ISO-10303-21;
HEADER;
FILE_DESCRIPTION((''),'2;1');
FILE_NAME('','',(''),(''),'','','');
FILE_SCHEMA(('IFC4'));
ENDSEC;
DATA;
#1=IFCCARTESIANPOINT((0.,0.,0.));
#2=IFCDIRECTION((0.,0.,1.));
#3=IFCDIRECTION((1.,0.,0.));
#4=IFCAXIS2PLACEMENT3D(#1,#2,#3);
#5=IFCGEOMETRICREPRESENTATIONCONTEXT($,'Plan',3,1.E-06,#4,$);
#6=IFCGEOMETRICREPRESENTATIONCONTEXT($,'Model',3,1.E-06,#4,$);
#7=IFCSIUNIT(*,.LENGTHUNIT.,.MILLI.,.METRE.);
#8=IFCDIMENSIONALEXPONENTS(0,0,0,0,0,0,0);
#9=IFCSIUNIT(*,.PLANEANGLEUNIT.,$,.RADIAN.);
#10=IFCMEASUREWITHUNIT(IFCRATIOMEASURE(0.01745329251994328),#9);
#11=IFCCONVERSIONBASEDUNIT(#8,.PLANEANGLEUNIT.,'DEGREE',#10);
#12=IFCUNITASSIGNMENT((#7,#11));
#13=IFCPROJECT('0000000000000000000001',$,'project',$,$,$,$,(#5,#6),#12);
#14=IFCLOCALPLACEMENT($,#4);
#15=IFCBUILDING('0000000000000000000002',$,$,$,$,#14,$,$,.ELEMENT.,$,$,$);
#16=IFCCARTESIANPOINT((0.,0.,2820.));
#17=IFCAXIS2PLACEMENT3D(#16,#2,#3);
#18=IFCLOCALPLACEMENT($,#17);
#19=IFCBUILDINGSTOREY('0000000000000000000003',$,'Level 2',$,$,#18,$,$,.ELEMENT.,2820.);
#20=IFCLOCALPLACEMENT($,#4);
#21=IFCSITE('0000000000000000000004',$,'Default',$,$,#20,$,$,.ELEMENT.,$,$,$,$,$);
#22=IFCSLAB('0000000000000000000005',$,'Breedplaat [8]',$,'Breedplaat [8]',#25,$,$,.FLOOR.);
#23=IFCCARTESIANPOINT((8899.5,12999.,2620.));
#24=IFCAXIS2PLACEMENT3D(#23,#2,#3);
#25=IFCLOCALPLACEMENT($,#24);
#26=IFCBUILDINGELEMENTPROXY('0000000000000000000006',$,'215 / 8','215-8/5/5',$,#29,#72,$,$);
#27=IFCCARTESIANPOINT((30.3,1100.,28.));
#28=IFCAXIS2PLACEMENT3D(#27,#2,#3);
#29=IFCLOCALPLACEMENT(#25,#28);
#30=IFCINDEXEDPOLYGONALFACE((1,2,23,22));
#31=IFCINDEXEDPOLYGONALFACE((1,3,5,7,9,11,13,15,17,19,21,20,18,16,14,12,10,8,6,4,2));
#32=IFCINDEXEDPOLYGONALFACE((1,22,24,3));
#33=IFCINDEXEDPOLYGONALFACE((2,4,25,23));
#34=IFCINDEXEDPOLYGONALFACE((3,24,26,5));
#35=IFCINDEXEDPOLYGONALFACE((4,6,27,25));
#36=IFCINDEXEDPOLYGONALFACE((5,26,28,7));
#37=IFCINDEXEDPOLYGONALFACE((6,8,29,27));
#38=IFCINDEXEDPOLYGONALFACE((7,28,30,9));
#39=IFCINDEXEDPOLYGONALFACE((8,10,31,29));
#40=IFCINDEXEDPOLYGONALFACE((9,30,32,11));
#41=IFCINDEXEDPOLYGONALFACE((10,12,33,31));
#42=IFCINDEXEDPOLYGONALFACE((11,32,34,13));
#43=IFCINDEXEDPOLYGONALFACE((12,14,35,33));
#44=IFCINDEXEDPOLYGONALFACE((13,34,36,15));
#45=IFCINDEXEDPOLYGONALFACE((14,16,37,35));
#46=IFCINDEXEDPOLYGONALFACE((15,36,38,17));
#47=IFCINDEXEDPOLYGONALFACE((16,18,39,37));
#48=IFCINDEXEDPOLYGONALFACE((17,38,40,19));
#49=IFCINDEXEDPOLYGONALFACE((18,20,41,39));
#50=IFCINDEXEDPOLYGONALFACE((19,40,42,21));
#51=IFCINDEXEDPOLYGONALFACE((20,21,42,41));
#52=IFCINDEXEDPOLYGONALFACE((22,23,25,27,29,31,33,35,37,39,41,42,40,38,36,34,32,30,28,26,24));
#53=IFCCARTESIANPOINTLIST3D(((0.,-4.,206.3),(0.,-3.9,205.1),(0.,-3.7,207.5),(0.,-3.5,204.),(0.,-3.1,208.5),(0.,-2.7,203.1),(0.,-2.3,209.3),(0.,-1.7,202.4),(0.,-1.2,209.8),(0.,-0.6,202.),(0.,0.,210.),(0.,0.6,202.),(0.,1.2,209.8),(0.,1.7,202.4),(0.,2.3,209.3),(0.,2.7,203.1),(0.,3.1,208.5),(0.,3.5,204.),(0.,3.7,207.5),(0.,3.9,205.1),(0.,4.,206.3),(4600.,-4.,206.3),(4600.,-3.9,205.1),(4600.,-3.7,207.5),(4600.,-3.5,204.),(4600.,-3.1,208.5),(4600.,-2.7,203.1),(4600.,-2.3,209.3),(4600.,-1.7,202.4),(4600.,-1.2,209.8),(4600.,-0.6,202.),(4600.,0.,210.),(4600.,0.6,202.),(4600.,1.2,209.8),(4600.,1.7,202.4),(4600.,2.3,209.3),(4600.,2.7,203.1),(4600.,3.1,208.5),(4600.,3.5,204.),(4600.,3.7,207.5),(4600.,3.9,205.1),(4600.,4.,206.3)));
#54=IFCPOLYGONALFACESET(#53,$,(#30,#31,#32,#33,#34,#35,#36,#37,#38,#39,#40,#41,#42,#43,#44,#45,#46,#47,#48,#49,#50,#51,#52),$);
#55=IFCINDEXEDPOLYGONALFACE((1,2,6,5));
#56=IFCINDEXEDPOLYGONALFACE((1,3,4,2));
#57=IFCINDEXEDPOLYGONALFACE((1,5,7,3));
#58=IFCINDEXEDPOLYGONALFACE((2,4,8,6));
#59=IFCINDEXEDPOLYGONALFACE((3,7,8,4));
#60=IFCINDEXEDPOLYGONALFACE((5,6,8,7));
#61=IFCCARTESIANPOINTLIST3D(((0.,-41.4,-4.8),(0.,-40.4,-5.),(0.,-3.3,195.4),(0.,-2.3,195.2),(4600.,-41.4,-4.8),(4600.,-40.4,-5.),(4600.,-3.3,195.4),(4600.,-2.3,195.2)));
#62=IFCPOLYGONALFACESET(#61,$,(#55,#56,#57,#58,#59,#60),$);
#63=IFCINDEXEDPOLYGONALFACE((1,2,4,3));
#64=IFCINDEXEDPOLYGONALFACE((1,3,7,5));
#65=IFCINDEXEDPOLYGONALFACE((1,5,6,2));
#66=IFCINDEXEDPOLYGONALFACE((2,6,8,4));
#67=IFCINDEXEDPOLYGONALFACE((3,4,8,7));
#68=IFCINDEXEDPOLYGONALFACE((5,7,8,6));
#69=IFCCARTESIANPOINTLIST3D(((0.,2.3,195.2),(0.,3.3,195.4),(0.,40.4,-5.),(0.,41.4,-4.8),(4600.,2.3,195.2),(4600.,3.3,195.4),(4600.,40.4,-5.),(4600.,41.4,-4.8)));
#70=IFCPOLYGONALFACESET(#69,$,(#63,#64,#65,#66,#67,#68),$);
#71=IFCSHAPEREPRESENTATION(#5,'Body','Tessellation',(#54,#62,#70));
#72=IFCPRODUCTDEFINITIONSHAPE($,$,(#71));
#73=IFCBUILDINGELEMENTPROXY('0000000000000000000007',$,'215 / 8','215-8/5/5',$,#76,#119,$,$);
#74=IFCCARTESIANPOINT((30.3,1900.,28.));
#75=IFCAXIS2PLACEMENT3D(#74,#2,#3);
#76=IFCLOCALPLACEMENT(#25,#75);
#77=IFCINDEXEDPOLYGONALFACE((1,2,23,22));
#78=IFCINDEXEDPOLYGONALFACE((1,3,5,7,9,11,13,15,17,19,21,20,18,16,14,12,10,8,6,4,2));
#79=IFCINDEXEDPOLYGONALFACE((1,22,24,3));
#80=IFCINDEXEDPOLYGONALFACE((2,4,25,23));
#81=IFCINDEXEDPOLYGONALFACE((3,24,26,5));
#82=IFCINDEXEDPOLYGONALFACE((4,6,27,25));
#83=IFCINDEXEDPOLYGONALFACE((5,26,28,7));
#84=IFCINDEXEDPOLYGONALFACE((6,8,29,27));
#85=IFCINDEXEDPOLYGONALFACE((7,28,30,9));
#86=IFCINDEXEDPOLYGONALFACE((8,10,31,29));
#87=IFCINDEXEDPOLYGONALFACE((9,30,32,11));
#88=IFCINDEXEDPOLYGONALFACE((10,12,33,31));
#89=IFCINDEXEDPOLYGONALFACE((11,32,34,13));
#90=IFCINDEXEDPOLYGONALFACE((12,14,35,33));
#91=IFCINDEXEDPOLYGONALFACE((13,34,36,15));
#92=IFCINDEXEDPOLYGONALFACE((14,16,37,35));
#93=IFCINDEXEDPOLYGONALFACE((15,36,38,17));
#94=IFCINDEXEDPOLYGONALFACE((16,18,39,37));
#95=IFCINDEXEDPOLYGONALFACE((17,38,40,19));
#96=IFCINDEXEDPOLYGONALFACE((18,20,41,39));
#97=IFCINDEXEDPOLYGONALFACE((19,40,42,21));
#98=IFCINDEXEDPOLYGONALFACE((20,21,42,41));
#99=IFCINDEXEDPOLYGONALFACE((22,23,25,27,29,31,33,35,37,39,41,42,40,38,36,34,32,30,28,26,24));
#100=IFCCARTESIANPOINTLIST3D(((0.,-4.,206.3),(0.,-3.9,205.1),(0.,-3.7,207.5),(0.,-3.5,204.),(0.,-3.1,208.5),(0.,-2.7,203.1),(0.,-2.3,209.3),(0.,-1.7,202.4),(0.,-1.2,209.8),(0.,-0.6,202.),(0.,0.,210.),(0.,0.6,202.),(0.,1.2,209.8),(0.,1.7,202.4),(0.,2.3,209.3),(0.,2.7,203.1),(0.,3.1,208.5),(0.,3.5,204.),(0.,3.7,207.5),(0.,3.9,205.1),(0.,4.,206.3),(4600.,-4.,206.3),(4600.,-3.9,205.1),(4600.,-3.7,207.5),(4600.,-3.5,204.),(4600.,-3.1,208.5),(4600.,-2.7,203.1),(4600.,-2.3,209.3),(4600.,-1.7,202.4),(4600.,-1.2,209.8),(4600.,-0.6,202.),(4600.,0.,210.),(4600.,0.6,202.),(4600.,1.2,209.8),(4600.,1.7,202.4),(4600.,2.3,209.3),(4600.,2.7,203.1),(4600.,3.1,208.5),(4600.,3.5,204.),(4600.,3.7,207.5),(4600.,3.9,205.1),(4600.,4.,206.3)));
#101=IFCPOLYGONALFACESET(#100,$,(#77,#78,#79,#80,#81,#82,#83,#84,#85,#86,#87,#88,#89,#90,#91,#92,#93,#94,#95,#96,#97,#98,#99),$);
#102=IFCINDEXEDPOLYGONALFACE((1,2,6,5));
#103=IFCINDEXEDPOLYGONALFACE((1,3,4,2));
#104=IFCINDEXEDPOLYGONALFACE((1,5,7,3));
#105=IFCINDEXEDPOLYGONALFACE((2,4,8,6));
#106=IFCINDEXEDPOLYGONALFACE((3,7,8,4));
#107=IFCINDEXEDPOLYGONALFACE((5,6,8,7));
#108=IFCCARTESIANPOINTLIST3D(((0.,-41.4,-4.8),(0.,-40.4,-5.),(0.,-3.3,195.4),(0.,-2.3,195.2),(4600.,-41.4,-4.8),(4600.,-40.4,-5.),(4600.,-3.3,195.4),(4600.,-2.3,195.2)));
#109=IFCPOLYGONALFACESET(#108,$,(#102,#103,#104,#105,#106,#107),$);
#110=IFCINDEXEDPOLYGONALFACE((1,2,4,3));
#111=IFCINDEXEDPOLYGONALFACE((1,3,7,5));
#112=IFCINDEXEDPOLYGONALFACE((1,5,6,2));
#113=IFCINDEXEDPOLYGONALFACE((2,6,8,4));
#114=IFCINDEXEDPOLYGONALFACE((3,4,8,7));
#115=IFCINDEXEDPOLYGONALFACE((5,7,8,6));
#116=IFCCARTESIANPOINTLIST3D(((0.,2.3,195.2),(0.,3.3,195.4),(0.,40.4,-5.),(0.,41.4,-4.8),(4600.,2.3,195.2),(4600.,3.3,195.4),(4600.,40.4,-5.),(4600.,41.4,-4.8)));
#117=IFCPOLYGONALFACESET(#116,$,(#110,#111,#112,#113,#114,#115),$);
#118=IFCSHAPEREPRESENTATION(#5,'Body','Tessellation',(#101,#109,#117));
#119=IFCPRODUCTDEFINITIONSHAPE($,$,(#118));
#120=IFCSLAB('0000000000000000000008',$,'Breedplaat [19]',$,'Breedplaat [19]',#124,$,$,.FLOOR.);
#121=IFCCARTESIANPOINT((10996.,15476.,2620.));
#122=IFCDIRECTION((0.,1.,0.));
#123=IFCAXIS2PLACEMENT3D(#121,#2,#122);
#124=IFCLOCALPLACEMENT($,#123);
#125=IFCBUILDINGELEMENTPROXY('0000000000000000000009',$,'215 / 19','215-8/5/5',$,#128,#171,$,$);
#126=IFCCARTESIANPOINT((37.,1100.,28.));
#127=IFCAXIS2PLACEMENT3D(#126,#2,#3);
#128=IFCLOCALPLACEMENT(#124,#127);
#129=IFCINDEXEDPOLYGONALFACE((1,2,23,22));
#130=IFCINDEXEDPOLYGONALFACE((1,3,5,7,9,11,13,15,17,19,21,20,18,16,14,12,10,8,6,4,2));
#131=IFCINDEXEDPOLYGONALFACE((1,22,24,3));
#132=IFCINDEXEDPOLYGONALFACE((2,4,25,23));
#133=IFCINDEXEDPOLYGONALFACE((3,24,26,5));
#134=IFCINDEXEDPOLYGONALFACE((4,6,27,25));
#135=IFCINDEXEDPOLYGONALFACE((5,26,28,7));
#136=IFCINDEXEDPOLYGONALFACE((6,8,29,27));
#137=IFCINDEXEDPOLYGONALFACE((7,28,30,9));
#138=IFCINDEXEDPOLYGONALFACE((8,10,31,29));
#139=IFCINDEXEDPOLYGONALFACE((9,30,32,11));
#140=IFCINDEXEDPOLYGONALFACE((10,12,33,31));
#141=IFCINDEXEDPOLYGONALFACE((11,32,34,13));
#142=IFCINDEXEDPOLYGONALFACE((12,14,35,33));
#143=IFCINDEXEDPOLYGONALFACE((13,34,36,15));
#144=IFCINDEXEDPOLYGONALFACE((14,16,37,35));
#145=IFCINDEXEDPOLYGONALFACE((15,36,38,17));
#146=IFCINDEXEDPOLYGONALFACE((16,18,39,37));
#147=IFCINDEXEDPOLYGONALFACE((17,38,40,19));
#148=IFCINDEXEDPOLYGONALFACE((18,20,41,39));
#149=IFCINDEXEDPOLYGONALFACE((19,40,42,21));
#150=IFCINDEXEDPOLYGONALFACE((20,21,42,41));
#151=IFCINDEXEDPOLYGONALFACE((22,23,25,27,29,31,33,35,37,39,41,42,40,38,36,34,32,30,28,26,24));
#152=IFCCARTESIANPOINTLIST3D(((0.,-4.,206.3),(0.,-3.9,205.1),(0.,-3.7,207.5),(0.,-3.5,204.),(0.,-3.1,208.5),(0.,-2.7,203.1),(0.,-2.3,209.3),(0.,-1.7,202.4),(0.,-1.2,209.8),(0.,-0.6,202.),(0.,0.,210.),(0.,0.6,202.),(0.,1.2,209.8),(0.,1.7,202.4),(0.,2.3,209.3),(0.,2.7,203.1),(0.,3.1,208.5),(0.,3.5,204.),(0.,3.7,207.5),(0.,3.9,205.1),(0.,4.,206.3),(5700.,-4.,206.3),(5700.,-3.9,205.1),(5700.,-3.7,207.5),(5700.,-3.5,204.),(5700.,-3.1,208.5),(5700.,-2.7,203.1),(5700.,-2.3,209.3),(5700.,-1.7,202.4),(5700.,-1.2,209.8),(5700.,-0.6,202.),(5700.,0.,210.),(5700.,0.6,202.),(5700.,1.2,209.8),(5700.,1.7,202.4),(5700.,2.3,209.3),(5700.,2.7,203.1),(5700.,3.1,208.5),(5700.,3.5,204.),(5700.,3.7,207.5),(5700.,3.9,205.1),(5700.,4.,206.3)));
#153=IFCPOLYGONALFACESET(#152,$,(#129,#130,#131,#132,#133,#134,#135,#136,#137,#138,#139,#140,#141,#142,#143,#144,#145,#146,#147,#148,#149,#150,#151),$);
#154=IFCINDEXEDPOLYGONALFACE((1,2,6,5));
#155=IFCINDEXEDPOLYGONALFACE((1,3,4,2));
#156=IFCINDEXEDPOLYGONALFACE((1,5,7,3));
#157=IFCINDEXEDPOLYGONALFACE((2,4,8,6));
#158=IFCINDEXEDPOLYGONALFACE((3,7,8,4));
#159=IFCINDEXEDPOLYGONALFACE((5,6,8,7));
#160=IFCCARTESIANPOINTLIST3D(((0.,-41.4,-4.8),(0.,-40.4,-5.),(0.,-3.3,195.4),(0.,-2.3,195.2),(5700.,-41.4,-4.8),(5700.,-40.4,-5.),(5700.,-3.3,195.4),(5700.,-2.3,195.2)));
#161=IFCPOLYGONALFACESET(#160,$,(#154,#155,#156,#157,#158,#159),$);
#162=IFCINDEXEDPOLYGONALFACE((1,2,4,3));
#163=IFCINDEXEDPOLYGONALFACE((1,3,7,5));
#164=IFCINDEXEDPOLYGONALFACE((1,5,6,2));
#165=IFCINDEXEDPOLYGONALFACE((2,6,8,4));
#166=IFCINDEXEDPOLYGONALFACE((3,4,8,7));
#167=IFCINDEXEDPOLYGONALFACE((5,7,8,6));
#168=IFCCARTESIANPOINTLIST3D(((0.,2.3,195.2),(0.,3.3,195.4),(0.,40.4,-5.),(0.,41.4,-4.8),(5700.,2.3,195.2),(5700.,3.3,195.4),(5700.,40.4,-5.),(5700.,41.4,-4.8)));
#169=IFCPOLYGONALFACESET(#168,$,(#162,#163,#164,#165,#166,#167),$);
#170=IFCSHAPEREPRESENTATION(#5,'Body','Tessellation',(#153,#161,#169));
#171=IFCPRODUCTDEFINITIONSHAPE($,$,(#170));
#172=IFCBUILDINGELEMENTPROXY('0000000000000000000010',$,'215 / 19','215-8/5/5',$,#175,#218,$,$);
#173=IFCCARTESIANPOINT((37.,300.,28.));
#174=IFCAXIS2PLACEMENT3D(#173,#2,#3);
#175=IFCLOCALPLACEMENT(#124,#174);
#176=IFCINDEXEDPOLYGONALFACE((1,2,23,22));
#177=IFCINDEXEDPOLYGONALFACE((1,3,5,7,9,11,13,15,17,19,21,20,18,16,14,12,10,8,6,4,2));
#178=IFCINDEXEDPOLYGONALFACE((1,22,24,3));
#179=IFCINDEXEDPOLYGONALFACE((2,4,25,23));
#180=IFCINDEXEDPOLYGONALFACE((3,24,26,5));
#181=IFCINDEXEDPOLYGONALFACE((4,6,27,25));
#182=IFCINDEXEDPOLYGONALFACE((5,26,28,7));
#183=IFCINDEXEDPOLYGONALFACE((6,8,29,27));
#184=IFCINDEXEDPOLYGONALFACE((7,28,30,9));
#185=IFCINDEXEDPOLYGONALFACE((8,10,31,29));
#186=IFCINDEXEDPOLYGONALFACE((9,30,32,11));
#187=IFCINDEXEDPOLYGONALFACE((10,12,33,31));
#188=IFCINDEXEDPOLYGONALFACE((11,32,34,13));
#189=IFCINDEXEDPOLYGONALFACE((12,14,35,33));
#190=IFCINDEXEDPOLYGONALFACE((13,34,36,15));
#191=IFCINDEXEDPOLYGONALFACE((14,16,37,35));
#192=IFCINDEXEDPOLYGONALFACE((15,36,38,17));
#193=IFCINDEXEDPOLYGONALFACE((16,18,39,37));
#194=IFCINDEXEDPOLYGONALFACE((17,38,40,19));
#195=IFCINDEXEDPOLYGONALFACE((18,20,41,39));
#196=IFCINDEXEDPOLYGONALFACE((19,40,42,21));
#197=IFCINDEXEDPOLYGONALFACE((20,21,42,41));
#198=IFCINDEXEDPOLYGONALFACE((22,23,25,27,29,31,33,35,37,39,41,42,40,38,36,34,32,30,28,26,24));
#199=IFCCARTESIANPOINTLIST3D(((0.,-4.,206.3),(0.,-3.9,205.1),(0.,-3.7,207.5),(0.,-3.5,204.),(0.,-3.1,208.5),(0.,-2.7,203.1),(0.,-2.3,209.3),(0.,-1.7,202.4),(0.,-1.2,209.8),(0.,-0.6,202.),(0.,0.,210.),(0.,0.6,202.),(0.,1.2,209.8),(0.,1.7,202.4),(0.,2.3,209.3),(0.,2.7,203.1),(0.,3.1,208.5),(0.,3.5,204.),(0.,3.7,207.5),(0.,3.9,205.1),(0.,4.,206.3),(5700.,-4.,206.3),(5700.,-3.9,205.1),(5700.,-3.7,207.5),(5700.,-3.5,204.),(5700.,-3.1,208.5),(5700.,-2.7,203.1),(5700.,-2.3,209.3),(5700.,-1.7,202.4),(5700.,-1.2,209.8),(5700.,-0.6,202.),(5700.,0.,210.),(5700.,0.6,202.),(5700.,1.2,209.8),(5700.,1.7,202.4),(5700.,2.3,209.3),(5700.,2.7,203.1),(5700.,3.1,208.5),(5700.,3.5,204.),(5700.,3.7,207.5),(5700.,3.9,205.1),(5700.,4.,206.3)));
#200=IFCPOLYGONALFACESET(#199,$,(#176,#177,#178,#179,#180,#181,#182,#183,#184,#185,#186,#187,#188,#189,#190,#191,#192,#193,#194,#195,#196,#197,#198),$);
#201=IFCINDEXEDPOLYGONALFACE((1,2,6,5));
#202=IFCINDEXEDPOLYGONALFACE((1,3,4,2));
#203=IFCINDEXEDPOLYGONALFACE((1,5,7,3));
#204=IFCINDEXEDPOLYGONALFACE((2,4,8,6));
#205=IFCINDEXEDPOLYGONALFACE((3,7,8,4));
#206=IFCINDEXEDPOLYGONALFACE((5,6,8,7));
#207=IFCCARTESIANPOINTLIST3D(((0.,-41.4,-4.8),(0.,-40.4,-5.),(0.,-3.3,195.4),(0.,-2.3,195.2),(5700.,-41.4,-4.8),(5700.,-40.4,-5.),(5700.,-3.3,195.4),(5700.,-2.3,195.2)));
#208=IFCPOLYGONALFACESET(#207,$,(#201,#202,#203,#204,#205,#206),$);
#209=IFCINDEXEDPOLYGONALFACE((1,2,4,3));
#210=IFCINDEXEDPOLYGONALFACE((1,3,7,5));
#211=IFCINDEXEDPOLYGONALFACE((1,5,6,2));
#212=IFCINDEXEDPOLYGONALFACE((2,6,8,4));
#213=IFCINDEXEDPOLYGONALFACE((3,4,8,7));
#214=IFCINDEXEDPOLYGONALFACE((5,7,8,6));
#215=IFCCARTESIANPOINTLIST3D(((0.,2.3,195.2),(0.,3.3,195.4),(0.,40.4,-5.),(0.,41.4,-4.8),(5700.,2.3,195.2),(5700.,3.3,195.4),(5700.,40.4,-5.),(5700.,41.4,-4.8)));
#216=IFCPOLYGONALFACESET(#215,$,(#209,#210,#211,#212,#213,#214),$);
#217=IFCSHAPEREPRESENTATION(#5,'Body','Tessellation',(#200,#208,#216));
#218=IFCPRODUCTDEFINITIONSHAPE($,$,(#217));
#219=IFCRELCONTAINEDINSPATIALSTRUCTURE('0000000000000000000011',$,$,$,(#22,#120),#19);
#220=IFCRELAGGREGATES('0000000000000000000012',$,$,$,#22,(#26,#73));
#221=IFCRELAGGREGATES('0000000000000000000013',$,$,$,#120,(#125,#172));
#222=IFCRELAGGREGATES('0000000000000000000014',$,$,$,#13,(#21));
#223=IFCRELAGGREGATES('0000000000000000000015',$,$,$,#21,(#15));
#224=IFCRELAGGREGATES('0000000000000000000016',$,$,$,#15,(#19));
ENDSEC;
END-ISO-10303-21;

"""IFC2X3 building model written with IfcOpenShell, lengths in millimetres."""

from ifc_helpers import new_model, entity, si_unit, converted_unit, frame, origin_with_axes, origin_2d_with_axis, place, context, project, spatial, rectangle, circle, extrude, element, aggregate, save


model = new_model("IFC2X3")

# Units and contexts
plan_context = context("Plan", 3, precision=1e-06, world=origin_with_axes())
model_context = context("Model", 3, precision=1e-06, world=origin_with_axes())
ifc_project = project(units=[si_unit("LENGTHUNIT", "METRE", prefix="MILLI"), converted_unit("PLANEANGLEUNIT", "DEGREE", entity("IfcRatioMeasure", 0.01745329251994328), si_unit("PLANEANGLEUNIT", "RADIAN"), dimensions=[0, 0, 0, 0, 0, 0, 0])], contexts=[plan_context, model_context])

# Site, building, storey
site_placement = place(None, origin_with_axes())
site = spatial("IfcSite", under=ifc_project, at=site_placement, Name="Default", CompositionType="ELEMENT")
building_placement = place(None, origin_with_axes())
building = spatial("IfcBuilding", under=site, at=building_placement, CompositionType="ELEMENT")
storey_placement = place(None, frame((0.0, 0.0, 2820.0), z_axis=(0.0, 0.0, 1.0), x_axis=(1.0, 0.0, 0.0)))
storey = spatial("IfcBuildingStorey", under=building, at=storey_placement, Name="Level 2", CompositionType="ELEMENT", Elevation=2820.0)

# Slabs, building element proxies
slab_1_placement = place(None, frame((8899.5, 12999.0, 2620.0), z_axis=(0.0, 0.0, 1.0), x_axis=(1.0, 0.0, 0.0)))
slab_1 = element("IfcSlab", 1, at=slab_1_placement, inside=storey, Name="Breedplaat [8]", ObjectType="Breedplaat [8]", PredefinedType="FLOOR")
proxy_1_placement = place(slab_1_placement, frame((30.3, 1100.0, 28.0), z_axis=(0.0, 0.0, 1.0), x_axis=(1.0, 0.0, 0.0)))
proxy_1 = element("IfcBuildingElementProxy", 2, at=proxy_1_placement, Name="215 / 8", Description="215-8/5/5", context=plan_context, shape_type="SweptSolid", body=[
    extrude(circle(Radius=4.0, at=origin_2d_with_axis()), frame((0.0, 0.0, 206.0), z_axis=(1.0, 0.0, 0.0), x_axis=(0.0, 0.0, 1.0)), (0.0, 0.0, 1.0), 4600.0),
    extrude(rectangle(XDim=203.8, YDim=1.0, at=origin_2d_with_axis()), frame((0.0, -21.9, 95.2), z_axis=(1.0, 0.0, 0.0), x_axis=(0.0, 0.187112, 0.982339)), (0.0, 0.0, 1.0), 4600.0),
    extrude(rectangle(XDim=203.8, YDim=1.0, at=origin_2d_with_axis()), frame((0.0, 21.9, 95.2), z_axis=(1.0, 0.0, 0.0), x_axis=(0.0, -0.187112, 0.982339)), (0.0, 0.0, 1.0), 4600.0),
])
proxy_2_placement = place(slab_1_placement, frame((30.3, 1900.0, 28.0), z_axis=(0.0, 0.0, 1.0), x_axis=(1.0, 0.0, 0.0)))
proxy_2 = element("IfcBuildingElementProxy", 3, at=proxy_2_placement, Name="215 / 8", Description="215-8/5/5", context=plan_context, shape_type="SweptSolid", body=[
    extrude(circle(Radius=4.0, at=origin_2d_with_axis()), frame((0.0, 0.0, 206.0), z_axis=(1.0, 0.0, 0.0), x_axis=(0.0, 0.0, 1.0)), (0.0, 0.0, 1.0), 4600.0),
    extrude(rectangle(XDim=203.8, YDim=1.0, at=origin_2d_with_axis()), frame((0.0, -21.9, 95.2), z_axis=(1.0, 0.0, 0.0), x_axis=(0.0, 0.187112, 0.982339)), (0.0, 0.0, 1.0), 4600.0),
    extrude(rectangle(XDim=203.8, YDim=1.0, at=origin_2d_with_axis()), frame((0.0, 21.9, 95.2), z_axis=(1.0, 0.0, 0.0), x_axis=(0.0, -0.187112, 0.982339)), (0.0, 0.0, 1.0), 4600.0),
])
aggregate(slab_1, [proxy_1, proxy_2])
slab_2_placement = place(None, frame((10996.0, 15476.0, 2620.0), z_axis=(0.0, 0.0, 1.0), x_axis=(0.0, 1.0, 0.0)))
slab_2 = element("IfcSlab", 4, at=slab_2_placement, inside=storey, Name="Breedplaat [19]", ObjectType="Breedplaat [19]", PredefinedType="FLOOR")
proxy_3_placement = place(slab_2_placement, frame((37.0, 1100.0, 28.0), z_axis=(0.0, 0.0, 1.0), x_axis=(1.0, 0.0, 0.0)))
proxy_3 = element("IfcBuildingElementProxy", 5, at=proxy_3_placement, Name="215 / 19", Description="215-8/5/5", context=plan_context, shape_type="SweptSolid", body=[
    extrude(circle(Radius=4.0, at=origin_2d_with_axis()), frame((0.0, 0.0, 206.0), z_axis=(1.0, 0.0, 0.0), x_axis=(0.0, 0.0, 1.0)), (0.0, 0.0, 1.0), 5700.0),
    extrude(rectangle(XDim=203.8, YDim=1.0, at=origin_2d_with_axis()), frame((0.0, -21.9, 95.2), z_axis=(1.0, 0.0, 0.0), x_axis=(0.0, 0.187112, 0.982339)), (0.0, 0.0, 1.0), 5700.0),
    extrude(rectangle(XDim=203.8, YDim=1.0, at=origin_2d_with_axis()), frame((0.0, 21.9, 95.2), z_axis=(1.0, 0.0, 0.0), x_axis=(0.0, -0.187112, 0.982339)), (0.0, 0.0, 1.0), 5700.0),
])
proxy_4_placement = place(slab_2_placement, frame((37.0, 300.0, 28.0), z_axis=(0.0, 0.0, 1.0), x_axis=(1.0, 0.0, 0.0)))
proxy_4 = element("IfcBuildingElementProxy", 6, at=proxy_4_placement, Name="215 / 19", Description="215-8/5/5", context=plan_context, shape_type="SweptSolid", body=[
    extrude(circle(Radius=4.0, at=origin_2d_with_axis()), frame((0.0, 0.0, 206.0), z_axis=(1.0, 0.0, 0.0), x_axis=(0.0, 0.0, 1.0)), (0.0, 0.0, 1.0), 5700.0),
    extrude(rectangle(XDim=203.8, YDim=1.0, at=origin_2d_with_axis()), frame((0.0, -21.9, 95.2), z_axis=(1.0, 0.0, 0.0), x_axis=(0.0, 0.187112, 0.982339)), (0.0, 0.0, 1.0), 5700.0),
    extrude(rectangle(XDim=203.8, YDim=1.0, at=origin_2d_with_axis()), frame((0.0, 21.9, 95.2), z_axis=(1.0, 0.0, 0.0), x_axis=(0.0, -0.187112, 0.982339)), (0.0, 0.0, 1.0), 5700.0),
])
aggregate(slab_2, [proxy_3, proxy_4])

save(model, "model.ifc")
